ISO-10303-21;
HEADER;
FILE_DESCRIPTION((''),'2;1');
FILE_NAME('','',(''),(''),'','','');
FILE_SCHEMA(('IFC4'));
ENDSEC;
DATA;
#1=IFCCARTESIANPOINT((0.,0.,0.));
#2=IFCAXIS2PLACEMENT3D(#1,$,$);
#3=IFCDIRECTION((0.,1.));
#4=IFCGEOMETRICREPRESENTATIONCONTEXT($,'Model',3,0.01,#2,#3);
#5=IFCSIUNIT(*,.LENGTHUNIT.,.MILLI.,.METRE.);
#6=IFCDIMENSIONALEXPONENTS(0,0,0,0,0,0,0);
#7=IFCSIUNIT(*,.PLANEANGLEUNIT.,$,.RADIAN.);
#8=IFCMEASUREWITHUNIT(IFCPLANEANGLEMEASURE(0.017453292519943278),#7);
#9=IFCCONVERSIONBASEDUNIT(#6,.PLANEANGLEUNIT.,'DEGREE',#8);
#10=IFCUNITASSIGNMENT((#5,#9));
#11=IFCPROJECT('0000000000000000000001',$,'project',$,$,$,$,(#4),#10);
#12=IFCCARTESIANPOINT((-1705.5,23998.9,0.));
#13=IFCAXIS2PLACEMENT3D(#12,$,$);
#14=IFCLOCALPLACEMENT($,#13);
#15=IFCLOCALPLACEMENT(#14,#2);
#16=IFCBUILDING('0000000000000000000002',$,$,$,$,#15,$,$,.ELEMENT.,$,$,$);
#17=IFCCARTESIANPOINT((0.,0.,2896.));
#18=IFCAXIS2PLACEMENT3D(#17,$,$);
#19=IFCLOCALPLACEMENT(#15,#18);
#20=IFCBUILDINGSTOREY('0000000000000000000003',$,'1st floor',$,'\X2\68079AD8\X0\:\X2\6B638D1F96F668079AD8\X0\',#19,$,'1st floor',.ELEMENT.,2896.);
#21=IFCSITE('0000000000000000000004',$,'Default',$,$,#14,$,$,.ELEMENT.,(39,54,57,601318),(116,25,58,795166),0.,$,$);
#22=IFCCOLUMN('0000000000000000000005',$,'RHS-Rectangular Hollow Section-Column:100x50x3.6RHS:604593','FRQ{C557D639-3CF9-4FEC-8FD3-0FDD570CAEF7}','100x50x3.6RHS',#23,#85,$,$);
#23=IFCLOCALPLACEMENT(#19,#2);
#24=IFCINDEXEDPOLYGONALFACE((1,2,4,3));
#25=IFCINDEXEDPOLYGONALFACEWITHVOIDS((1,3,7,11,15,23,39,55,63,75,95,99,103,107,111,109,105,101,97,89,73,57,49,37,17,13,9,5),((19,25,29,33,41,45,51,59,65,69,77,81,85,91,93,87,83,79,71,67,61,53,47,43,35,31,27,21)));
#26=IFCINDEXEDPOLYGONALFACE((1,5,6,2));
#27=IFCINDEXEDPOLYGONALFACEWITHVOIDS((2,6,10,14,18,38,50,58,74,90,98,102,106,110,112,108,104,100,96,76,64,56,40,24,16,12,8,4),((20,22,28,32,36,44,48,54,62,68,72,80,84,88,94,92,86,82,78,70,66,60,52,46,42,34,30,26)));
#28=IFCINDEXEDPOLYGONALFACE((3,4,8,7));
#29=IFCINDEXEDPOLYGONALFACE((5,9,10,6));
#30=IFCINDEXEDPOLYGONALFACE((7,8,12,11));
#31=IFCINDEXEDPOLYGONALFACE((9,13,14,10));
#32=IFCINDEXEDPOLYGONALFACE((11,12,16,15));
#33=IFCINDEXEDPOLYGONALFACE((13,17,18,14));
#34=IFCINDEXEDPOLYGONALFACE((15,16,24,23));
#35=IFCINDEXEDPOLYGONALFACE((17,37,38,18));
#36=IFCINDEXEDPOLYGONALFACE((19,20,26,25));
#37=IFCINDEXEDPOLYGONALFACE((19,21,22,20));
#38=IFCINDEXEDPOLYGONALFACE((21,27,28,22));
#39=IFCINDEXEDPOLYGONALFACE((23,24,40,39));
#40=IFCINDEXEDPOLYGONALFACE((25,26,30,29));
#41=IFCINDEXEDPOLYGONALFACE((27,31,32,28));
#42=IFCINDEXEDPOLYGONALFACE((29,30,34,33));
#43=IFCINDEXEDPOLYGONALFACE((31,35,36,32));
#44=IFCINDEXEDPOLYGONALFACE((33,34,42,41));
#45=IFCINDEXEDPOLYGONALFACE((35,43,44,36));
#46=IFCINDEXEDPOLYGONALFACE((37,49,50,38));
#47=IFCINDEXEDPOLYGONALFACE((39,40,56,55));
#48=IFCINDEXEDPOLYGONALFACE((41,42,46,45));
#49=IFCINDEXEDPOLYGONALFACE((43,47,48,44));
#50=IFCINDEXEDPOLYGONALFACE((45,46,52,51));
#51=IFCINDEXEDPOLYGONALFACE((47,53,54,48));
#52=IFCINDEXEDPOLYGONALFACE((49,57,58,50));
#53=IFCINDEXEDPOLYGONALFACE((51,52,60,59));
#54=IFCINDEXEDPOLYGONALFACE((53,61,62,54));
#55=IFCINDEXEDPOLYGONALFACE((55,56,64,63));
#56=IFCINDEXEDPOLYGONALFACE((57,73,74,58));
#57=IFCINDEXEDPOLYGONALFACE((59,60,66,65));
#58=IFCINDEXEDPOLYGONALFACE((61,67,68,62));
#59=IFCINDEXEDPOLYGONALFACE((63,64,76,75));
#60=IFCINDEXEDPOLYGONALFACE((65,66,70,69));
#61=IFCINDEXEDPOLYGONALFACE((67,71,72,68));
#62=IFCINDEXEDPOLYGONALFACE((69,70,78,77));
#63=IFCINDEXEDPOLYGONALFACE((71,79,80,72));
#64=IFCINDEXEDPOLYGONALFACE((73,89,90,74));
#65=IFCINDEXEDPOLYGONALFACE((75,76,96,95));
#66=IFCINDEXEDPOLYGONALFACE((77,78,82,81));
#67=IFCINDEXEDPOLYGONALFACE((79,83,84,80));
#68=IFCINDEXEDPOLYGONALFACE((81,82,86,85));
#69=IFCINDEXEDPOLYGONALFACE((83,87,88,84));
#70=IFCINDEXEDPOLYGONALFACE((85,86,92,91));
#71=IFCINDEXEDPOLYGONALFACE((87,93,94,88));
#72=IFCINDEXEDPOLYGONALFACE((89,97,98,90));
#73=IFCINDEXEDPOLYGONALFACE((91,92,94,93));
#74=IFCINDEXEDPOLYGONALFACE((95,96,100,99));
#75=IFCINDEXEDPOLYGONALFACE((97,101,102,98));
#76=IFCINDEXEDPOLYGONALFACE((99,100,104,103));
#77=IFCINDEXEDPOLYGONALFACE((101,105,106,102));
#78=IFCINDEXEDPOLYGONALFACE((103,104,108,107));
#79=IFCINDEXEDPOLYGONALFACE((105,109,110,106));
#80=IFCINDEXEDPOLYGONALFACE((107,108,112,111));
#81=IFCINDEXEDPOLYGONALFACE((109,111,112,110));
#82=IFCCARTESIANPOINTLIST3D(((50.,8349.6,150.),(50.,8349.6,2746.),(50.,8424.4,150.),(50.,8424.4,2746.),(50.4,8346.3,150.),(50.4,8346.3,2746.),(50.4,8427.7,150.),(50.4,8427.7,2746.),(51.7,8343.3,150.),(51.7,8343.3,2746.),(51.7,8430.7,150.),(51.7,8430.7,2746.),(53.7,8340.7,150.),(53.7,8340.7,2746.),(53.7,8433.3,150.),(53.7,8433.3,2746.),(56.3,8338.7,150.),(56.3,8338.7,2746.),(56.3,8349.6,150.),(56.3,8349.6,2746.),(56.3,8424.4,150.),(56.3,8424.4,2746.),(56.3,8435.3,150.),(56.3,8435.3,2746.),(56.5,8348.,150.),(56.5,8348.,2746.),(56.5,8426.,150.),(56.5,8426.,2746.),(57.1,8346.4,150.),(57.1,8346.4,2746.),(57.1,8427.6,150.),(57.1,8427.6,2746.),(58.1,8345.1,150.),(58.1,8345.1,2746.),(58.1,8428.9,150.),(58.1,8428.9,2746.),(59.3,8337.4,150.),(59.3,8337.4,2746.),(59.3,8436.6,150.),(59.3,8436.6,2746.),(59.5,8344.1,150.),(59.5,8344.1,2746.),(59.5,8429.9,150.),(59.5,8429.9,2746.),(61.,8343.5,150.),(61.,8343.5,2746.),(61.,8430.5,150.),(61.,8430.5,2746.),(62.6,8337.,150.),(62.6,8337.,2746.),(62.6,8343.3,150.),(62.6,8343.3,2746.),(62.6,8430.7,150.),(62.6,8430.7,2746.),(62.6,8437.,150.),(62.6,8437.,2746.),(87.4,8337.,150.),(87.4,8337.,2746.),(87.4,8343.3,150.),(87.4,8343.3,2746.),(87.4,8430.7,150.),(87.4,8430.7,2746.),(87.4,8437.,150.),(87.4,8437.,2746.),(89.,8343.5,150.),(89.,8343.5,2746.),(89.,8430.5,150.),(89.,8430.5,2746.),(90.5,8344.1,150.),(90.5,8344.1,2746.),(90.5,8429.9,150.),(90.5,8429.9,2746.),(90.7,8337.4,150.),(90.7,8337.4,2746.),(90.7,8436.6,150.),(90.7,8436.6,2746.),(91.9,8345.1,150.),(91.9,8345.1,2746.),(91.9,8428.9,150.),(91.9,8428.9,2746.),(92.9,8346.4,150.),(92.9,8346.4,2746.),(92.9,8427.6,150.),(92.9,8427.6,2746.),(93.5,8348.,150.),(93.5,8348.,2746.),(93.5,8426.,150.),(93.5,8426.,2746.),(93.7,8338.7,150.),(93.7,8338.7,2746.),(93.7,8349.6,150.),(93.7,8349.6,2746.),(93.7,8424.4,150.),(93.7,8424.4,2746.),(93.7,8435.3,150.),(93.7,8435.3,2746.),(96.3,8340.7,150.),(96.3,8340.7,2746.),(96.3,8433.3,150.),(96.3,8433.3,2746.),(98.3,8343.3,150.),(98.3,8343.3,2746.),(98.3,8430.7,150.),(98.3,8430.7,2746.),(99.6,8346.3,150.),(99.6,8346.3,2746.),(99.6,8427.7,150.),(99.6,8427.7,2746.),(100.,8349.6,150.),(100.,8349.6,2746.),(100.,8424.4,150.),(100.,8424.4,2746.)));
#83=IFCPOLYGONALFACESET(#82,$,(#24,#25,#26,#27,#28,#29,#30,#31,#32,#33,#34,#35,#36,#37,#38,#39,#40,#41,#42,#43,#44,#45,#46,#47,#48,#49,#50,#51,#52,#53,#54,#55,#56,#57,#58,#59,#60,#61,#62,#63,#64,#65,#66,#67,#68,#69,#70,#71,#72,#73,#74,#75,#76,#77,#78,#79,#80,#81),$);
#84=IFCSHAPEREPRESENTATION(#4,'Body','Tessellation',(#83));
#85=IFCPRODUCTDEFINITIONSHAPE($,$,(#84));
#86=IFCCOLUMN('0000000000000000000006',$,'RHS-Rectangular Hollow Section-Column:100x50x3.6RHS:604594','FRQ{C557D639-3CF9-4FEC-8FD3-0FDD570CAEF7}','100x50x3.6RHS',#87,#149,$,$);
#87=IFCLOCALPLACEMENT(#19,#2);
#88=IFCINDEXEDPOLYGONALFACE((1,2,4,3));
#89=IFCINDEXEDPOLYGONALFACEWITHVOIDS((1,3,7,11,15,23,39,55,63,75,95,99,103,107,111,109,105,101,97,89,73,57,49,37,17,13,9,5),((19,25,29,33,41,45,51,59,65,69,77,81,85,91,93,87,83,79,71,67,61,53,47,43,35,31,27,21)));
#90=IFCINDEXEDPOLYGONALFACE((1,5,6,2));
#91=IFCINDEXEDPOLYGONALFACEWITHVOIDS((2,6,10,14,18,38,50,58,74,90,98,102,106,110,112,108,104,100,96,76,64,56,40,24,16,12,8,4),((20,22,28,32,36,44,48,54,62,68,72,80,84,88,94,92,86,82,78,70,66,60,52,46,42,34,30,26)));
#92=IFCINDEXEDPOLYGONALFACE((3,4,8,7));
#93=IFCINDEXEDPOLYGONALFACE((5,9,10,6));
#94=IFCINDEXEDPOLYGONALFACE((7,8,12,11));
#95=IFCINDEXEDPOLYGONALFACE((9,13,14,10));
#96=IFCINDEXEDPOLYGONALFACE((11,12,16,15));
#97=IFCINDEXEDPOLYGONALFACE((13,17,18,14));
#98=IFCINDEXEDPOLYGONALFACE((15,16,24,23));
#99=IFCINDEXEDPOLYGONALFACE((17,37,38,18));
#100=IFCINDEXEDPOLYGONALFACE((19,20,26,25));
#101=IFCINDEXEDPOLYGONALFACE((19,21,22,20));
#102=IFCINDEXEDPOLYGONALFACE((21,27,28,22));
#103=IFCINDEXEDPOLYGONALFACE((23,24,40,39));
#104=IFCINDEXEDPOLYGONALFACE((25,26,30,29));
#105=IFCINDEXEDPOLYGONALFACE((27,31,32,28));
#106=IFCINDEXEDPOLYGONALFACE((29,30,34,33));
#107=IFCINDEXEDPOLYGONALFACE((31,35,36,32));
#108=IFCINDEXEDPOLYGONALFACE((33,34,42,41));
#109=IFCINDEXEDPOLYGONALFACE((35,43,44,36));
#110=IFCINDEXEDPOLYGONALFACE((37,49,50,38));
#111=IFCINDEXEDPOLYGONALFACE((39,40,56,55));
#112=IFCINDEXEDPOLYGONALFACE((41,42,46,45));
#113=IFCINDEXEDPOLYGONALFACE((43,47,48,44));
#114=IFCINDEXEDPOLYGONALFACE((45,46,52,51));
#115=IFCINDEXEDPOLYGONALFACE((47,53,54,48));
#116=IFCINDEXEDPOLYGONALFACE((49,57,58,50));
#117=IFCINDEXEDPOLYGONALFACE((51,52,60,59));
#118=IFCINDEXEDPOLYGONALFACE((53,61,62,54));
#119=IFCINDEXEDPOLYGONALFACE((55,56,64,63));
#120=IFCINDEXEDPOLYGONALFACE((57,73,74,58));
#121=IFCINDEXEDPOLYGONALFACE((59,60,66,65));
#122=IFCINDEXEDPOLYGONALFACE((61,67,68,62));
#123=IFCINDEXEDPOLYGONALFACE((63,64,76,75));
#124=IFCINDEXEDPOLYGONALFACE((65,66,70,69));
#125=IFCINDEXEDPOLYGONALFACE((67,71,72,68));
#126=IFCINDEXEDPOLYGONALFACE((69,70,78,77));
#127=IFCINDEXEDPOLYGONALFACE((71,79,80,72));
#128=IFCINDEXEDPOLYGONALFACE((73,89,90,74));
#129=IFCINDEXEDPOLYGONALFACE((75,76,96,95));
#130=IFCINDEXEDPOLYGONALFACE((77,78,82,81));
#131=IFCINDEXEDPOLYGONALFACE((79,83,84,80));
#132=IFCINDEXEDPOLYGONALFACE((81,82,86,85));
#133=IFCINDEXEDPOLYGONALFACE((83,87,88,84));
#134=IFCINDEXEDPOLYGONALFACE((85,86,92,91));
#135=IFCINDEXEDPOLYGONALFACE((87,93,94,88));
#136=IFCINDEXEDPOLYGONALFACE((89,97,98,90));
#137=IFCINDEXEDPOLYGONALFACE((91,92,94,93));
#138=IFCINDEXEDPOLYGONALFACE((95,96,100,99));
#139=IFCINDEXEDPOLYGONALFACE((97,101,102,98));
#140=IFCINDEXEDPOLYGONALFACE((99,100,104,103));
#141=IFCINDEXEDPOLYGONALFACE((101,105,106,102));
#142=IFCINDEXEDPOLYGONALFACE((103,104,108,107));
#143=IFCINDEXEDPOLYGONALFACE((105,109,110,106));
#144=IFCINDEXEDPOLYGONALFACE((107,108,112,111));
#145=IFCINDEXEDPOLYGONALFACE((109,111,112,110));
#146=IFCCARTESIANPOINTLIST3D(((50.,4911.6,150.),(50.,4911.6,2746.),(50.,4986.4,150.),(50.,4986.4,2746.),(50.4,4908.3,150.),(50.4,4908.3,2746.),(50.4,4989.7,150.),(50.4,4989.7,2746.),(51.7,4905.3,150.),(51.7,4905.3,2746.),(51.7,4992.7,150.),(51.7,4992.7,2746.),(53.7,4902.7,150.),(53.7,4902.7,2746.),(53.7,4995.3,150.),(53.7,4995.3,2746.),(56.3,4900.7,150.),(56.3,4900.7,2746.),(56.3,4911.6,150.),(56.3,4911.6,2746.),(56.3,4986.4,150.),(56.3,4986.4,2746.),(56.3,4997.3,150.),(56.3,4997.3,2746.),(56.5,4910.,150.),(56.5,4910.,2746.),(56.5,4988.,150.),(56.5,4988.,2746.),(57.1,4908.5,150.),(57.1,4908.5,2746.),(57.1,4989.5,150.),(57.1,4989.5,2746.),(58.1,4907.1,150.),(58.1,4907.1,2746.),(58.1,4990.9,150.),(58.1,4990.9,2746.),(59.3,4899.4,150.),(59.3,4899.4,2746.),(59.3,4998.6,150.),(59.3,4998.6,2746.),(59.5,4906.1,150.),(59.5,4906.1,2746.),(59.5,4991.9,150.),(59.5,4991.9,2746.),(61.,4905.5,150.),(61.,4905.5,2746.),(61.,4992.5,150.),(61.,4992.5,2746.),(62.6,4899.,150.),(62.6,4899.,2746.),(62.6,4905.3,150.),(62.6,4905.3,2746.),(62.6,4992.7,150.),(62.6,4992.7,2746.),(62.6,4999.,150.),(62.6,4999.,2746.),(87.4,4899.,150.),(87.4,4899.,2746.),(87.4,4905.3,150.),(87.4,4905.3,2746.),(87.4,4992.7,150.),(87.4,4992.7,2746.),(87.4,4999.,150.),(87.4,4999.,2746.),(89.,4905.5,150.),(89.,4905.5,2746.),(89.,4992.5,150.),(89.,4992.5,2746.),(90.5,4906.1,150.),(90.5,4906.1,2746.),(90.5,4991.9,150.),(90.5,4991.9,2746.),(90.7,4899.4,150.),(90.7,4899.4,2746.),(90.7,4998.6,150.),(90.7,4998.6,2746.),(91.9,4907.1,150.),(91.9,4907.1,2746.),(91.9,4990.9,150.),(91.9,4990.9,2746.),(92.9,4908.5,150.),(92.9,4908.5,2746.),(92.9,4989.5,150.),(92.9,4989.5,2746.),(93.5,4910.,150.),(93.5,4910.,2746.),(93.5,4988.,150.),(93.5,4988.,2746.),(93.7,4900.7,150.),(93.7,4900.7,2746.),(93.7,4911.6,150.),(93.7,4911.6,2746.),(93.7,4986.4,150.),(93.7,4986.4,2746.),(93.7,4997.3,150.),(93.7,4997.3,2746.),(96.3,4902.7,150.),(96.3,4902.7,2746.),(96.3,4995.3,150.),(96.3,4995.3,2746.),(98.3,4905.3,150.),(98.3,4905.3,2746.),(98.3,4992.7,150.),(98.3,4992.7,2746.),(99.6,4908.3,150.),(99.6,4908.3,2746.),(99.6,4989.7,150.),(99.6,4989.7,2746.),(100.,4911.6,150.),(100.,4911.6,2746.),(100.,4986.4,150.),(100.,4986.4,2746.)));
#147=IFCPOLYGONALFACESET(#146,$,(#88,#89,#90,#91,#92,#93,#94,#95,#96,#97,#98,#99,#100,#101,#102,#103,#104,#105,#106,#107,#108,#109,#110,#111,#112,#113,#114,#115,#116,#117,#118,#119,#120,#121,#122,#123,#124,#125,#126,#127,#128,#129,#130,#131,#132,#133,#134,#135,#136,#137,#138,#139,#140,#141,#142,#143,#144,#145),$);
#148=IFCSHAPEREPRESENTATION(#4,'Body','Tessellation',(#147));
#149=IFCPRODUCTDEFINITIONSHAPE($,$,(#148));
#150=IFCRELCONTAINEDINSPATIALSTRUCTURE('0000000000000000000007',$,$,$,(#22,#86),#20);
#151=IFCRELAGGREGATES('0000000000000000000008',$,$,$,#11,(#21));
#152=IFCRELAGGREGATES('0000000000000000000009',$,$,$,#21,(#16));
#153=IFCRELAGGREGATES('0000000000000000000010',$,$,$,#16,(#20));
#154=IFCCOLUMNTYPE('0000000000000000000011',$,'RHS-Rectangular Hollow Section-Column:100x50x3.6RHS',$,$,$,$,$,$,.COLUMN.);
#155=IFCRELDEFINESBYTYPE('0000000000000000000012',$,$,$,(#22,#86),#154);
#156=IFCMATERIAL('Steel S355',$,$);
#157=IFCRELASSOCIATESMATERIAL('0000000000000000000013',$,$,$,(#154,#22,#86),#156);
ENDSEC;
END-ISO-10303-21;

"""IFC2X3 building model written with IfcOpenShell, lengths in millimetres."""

from ifc_helpers import new_model, entity, si_unit, converted_unit, direction, frame, origin, origin_2d, place, context, project, spatial, hollow_rectangle, extrude, clip, halfspace, material, type_object, element, save


model = new_model("IFC2X3")

# Units and contexts
model_context = context("Model", 3, precision=0.01, world=origin(), true_north=direction((0.0, 1.0)))
ifc_project = project(units=[si_unit("LENGTHUNIT", "METRE", prefix="MILLI"), converted_unit("PLANEANGLEUNIT", "DEGREE", entity("IfcPlaneAngleMeasure", 0.017453292519943278), si_unit("PLANEANGLEUNIT", "RADIAN"), dimensions=[0, 0, 0, 0, 0, 0, 0])], contexts=[model_context])

# Site, building, storey
site_placement = place(None, frame((-1705.5, 23998.9, 0.0)))
site = spatial("IfcSite", under=ifc_project, at=site_placement, Name="Default", CompositionType="ELEMENT", RefLatitude=(39, 54, 57, 601318), RefLongitude=(116, 25, 58, 795166), RefElevation=0.0)
building_placement = place(site_placement, origin())
building = spatial("IfcBuilding", under=site, at=building_placement, CompositionType="ELEMENT")
storey_placement = place(building_placement, frame((0.0, 0.0, 2896.0)))
storey = spatial("IfcBuildingStorey", under=building, at=storey_placement, Name="1st floor", ObjectType="标高:正负零标高", LongName="1st floor", CompositionType="ELEMENT", Elevation=2896.0)

# Columns
ifc_material_1 = material(Name="Steel S355")
column_type_1 = type_object("IfcColumnType", Name="RHS-Rectangular Hollow Section-Column:100x50x3.6RHS", PredefinedType="COLUMN", material=ifc_material_1)
column_1_placement = place(storey_placement, frame((75.0, 8387.0, 2746.0), z_axis=(0.0, 0.0, 1.0), x_axis=(-1.0, 0.0, 0.0)))
element("IfcColumn", 1, at=column_1_placement, inside=storey, type_object=column_type_1, material=ifc_material_1, Name="RHS-Rectangular Hollow Section-Column:100x50x3.6RHS:604593", Description="FRQ{C557D639-3CF9-4FEC-8FD3-0FDD570CAEF7}", ObjectType="100x50x3.6RHS", context=model_context, shape_type="Clipping", body=[
    clip(extrude(hollow_rectangle(XDim=50.0, YDim=100.0, WallThickness=6.3, InnerFilletRadius=6.3, OuterFilletRadius=12.6, at=origin_2d()), origin(), (0.0, 0.0, -1.0), 2651.9), halfspace(frame((75.0, 8387.0, -2596.0), z_axis=(0.0, 0.0, 1.0), x_axis=(-1.0, 0.0, 0.0)), True)),
])
column_2_placement = place(storey_placement, frame((75.0, 4949.0, 2746.0), z_axis=(0.0, 0.0, 1.0), x_axis=(-1.0, 0.0, 0.0)))
element("IfcColumn", 2, at=column_2_placement, inside=storey, type_object=column_type_1, material=ifc_material_1, Name="RHS-Rectangular Hollow Section-Column:100x50x3.6RHS:604594", Description="FRQ{C557D639-3CF9-4FEC-8FD3-0FDD570CAEF7}", ObjectType="100x50x3.6RHS", context=model_context, shape_type="Clipping", body=[
    clip(extrude(hollow_rectangle(XDim=50.0, YDim=100.0, WallThickness=6.3, InnerFilletRadius=6.3, OuterFilletRadius=12.6, at=origin_2d()), origin(), (0.0, 0.0, -1.0), 2651.9), halfspace(frame((75.0, 4949.0, -2596.0), z_axis=(0.0, 0.0, 1.0), x_axis=(-1.0, 0.0, 0.0)), True)),
])

save(model, "model.ifc")
